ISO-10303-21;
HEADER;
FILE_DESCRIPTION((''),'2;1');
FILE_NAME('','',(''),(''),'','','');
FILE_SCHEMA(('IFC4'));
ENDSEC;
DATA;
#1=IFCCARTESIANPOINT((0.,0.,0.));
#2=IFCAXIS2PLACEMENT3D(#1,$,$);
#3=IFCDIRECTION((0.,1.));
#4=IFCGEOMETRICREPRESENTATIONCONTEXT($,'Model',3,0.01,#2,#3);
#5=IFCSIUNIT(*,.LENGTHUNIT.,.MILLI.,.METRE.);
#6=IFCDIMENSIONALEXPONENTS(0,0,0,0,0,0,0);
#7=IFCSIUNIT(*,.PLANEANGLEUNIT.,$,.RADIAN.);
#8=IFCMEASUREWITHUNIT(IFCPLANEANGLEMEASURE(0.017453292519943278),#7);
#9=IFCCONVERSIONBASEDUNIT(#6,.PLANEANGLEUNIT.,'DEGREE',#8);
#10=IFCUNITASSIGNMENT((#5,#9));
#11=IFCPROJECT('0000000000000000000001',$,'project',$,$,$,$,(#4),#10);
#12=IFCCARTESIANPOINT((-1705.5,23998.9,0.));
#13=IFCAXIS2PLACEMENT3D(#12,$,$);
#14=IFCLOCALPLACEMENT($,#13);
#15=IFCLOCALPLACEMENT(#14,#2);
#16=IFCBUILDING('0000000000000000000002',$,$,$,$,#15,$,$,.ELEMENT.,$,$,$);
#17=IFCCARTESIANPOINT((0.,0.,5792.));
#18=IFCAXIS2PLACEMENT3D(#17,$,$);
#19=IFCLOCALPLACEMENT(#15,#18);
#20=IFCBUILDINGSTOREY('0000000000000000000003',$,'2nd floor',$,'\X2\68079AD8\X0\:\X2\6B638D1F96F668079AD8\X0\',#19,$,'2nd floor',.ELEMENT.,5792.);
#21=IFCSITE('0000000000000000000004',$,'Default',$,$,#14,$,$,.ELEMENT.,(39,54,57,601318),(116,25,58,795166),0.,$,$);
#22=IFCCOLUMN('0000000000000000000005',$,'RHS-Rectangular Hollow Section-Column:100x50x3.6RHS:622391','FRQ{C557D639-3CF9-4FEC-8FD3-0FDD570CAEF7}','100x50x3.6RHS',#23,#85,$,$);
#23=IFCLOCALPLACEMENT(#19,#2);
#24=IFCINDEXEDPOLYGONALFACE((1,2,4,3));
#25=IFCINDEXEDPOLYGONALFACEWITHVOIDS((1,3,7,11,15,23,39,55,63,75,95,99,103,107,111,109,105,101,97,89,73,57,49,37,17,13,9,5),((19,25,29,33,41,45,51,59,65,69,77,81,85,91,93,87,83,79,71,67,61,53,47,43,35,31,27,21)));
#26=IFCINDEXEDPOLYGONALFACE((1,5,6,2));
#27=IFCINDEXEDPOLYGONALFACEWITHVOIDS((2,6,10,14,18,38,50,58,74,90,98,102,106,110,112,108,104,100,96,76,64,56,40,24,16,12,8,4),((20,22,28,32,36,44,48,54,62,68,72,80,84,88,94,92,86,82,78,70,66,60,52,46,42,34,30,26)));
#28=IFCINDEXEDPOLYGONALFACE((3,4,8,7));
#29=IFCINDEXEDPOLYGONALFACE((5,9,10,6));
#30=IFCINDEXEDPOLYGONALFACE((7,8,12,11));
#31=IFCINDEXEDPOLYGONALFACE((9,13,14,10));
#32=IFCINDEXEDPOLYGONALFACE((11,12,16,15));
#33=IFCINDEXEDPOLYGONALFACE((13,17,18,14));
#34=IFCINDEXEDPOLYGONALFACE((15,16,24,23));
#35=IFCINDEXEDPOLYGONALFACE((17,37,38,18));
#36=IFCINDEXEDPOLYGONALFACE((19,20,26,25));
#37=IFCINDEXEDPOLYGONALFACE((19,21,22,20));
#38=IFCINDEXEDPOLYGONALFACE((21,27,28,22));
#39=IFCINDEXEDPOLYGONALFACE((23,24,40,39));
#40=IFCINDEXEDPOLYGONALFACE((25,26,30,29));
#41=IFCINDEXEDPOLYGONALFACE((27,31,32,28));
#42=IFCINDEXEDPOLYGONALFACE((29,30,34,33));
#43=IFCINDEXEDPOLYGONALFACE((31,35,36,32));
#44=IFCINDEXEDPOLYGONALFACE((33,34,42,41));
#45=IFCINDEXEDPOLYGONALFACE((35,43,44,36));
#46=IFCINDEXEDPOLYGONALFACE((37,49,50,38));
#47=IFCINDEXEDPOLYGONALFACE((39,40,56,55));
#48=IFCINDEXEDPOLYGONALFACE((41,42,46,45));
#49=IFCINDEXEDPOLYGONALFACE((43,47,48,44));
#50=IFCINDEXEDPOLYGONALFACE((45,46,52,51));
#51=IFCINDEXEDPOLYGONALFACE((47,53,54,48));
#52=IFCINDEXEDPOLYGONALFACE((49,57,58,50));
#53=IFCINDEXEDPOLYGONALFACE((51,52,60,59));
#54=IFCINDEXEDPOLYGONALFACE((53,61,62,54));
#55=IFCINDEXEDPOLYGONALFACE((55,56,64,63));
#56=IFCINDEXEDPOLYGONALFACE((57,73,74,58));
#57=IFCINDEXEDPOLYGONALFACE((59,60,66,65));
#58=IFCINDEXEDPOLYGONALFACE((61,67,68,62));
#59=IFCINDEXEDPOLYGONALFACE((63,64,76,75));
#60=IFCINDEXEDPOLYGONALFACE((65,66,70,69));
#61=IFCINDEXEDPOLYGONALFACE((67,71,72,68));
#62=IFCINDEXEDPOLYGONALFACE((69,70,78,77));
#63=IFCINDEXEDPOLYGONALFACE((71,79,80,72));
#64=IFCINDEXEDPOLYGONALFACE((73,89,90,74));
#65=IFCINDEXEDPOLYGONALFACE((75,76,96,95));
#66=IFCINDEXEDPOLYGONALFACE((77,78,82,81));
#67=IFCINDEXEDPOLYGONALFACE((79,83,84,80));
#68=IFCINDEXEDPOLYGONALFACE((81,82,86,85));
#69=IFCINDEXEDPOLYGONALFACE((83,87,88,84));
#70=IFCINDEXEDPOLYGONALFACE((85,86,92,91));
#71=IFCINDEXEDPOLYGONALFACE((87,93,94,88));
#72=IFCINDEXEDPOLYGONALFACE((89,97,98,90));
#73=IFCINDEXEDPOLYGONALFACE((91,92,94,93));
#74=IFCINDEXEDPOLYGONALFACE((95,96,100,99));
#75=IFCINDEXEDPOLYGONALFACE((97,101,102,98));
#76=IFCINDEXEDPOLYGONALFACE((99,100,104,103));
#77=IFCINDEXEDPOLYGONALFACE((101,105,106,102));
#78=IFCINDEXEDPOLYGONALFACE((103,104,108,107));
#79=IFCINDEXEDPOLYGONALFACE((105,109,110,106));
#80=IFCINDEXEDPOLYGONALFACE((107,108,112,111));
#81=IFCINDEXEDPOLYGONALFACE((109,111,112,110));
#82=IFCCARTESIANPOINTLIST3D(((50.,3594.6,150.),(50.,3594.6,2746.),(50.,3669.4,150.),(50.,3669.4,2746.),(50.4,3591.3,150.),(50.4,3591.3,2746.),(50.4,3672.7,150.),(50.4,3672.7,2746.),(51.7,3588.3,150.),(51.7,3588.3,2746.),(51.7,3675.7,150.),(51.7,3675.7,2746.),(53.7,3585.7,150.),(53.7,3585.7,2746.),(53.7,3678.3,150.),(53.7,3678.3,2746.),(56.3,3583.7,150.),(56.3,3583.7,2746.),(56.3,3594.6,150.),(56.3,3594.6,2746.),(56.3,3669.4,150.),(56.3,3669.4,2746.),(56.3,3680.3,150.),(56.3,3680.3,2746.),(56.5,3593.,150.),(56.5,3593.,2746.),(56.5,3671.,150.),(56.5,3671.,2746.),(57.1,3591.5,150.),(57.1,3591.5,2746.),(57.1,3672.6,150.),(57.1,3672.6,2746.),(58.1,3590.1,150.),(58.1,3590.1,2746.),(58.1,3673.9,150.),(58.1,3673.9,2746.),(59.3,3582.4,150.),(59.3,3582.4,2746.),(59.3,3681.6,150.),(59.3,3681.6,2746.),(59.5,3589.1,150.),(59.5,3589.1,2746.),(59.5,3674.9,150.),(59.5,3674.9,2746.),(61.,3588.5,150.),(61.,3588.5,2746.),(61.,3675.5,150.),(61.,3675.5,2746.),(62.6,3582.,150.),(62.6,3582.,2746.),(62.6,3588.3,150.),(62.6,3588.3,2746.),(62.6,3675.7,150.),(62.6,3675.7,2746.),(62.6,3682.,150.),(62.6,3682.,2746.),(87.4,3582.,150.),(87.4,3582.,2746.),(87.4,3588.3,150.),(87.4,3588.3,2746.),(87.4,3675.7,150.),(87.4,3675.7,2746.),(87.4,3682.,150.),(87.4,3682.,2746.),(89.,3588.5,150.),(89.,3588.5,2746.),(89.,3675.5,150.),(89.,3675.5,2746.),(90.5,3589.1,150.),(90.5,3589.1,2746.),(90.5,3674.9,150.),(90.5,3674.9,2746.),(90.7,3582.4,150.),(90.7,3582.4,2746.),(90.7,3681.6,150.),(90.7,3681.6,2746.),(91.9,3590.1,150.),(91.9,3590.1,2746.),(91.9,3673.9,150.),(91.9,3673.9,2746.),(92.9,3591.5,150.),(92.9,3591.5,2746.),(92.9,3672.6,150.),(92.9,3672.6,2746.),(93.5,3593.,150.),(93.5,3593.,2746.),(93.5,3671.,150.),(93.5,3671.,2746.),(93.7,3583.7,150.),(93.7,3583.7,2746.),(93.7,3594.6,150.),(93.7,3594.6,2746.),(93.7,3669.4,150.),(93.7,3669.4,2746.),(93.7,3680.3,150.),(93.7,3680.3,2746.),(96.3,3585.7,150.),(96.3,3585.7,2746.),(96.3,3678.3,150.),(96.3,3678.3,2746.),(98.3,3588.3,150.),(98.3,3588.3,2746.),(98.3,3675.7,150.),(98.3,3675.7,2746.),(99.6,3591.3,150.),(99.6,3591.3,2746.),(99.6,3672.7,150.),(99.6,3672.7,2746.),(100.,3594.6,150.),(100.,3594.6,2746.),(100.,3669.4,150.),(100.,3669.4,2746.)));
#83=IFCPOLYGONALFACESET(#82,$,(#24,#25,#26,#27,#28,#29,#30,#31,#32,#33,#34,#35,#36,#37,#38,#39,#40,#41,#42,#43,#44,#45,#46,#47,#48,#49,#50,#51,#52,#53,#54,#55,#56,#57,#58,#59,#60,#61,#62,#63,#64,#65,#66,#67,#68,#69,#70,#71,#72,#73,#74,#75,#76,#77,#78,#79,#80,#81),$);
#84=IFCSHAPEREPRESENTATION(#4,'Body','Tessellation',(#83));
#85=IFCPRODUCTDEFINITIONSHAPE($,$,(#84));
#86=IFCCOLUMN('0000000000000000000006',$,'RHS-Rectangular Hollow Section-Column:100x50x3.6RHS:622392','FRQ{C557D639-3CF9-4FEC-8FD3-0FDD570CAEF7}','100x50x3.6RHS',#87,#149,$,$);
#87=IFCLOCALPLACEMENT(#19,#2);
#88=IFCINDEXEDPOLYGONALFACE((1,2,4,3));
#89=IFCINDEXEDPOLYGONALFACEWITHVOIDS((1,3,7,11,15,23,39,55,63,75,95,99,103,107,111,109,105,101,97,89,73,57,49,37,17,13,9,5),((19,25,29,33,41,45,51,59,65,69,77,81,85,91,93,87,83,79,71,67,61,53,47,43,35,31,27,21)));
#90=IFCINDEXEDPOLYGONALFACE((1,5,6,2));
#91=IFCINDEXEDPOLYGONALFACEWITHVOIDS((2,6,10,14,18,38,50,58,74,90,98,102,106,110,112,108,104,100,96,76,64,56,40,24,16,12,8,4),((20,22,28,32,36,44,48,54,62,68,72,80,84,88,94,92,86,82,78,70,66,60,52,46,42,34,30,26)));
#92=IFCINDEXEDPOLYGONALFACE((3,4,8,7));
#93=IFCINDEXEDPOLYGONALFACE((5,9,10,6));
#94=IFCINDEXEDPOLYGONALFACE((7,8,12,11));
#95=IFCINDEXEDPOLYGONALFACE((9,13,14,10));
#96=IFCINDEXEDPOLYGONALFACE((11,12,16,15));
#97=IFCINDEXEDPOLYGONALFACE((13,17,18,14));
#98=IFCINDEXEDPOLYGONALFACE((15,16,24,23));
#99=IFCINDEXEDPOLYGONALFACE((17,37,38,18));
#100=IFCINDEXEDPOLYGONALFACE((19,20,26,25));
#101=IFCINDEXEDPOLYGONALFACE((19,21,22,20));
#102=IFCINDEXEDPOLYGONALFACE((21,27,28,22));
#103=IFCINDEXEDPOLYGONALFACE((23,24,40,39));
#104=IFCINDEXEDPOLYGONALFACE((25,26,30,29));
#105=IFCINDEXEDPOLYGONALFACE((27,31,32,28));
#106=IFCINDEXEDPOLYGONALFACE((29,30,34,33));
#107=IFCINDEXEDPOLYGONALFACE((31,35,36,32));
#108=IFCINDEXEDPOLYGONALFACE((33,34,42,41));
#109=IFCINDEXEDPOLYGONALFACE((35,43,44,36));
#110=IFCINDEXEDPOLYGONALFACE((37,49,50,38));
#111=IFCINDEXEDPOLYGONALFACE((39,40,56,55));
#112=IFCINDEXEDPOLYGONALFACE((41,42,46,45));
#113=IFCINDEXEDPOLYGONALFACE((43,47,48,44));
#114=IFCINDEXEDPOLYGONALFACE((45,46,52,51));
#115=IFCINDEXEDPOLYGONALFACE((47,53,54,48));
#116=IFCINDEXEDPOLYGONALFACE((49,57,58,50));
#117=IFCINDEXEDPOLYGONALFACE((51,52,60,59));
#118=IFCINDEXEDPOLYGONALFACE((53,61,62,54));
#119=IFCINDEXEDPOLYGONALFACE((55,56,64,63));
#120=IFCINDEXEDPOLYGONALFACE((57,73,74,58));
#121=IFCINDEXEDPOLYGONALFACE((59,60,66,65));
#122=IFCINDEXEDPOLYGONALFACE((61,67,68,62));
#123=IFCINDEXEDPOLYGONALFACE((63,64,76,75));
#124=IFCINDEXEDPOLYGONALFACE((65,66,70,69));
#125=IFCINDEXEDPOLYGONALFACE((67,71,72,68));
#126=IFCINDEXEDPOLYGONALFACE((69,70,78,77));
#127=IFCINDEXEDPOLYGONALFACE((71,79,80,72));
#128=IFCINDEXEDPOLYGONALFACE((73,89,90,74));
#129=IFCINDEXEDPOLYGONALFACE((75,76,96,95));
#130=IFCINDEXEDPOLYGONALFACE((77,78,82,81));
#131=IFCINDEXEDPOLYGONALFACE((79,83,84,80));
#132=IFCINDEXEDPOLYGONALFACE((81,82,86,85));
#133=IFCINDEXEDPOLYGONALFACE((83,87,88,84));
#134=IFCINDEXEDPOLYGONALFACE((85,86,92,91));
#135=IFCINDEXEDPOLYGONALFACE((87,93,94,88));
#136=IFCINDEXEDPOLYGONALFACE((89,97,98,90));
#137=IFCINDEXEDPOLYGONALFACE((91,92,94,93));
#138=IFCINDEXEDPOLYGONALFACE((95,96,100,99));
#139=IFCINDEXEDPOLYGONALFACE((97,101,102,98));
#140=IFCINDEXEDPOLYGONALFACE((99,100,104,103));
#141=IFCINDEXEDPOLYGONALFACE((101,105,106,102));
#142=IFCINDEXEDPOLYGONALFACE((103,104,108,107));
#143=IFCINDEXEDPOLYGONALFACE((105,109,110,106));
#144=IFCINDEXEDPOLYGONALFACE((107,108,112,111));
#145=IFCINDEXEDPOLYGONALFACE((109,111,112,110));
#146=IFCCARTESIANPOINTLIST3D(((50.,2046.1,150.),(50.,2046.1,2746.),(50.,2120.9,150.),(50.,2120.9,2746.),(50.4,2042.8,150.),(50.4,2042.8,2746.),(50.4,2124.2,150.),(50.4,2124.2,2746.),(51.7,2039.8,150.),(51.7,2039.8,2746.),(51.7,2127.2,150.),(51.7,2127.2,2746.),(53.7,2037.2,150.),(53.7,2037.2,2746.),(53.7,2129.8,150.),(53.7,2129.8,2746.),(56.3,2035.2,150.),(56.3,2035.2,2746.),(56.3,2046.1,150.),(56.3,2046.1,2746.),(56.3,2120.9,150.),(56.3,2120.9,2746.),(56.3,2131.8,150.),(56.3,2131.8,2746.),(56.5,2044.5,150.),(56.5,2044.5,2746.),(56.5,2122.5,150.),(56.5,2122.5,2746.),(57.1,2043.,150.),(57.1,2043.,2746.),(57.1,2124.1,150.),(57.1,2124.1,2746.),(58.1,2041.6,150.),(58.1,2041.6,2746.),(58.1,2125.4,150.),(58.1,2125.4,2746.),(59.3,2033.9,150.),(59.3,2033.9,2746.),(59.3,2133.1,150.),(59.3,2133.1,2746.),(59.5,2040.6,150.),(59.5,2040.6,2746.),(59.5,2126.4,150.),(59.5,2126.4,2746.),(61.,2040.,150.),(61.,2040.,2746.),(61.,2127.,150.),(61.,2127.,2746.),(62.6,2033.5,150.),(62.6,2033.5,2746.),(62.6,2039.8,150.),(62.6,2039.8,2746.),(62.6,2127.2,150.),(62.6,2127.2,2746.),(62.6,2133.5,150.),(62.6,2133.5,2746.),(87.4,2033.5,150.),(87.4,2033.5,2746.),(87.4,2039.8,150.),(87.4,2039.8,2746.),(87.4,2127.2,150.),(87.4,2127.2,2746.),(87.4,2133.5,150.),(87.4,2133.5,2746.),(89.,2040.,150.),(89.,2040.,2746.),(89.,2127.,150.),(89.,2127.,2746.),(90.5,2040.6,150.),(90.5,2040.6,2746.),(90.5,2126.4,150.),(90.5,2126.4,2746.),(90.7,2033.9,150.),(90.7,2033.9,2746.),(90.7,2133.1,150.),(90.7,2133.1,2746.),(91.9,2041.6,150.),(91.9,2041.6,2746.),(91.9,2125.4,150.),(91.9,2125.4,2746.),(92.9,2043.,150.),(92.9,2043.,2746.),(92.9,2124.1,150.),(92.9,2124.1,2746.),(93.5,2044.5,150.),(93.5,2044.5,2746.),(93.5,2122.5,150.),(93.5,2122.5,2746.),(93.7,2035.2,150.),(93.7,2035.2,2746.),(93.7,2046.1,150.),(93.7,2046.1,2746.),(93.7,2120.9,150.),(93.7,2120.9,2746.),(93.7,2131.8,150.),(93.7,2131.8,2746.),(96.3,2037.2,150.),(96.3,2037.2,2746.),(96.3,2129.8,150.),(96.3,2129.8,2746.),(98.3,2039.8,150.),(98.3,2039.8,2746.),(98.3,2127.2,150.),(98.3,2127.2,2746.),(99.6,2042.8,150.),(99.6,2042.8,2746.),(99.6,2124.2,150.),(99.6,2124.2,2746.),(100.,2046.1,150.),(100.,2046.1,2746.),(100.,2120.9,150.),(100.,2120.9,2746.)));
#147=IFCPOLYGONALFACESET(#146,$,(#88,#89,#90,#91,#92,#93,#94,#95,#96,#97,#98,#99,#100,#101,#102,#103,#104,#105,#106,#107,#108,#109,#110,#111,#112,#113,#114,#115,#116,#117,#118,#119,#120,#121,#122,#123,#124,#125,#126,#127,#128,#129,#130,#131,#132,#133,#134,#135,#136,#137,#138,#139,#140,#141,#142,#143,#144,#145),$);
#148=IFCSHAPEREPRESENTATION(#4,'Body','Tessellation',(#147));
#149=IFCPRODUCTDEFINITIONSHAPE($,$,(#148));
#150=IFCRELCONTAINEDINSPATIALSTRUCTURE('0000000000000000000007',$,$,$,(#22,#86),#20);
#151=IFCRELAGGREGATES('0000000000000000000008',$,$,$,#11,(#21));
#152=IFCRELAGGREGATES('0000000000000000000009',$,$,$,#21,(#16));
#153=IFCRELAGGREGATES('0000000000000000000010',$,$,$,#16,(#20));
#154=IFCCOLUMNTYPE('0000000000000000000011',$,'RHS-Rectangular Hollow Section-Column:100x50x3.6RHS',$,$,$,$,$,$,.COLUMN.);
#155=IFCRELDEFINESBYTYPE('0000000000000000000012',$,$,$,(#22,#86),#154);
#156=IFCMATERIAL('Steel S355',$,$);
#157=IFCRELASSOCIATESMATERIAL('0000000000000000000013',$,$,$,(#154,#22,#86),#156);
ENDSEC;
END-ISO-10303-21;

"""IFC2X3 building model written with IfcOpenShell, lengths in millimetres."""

from ifc_helpers import new_model, entity, si_unit, converted_unit, direction, frame, origin, origin_2d, place, context, project, spatial, hollow_rectangle, extrude, clip, halfspace, material, type_object, element, save


model = new_model("IFC2X3")

# Units and contexts
model_context = context("Model", 3, precision=0.01, world=origin(), true_north=direction((0.0, 1.0)))
ifc_project = project(units=[si_unit("LENGTHUNIT", "METRE", prefix="MILLI"), converted_unit("PLANEANGLEUNIT", "DEGREE", entity("IfcPlaneAngleMeasure", 0.017453292519943278), si_unit("PLANEANGLEUNIT", "RADIAN"), dimensions=[0, 0, 0, 0, 0, 0, 0])], contexts=[model_context])

# Site, building, storey
site_placement = place(None, frame((-1705.5, 23998.9, 0.0)))
site = spatial("IfcSite", under=ifc_project, at=site_placement, Name="Default", CompositionType="ELEMENT", RefLatitude=(39, 54, 57, 601318), RefLongitude=(116, 25, 58, 795166), RefElevation=0.0)
building_placement = place(site_placement, origin())
building = spatial("IfcBuilding", under=site, at=building_placement, CompositionType="ELEMENT")
storey_placement = place(building_placement, frame((0.0, 0.0, 5792.0)))
storey = spatial("IfcBuildingStorey", under=building, at=storey_placement, Name="2nd floor", ObjectType="标高:正负零标高", LongName="2nd floor", CompositionType="ELEMENT", Elevation=5792.0)

# Columns
ifc_material_1 = material(Name="Steel S355")
column_type_1 = type_object("IfcColumnType", Name="RHS-Rectangular Hollow Section-Column:100x50x3.6RHS", PredefinedType="COLUMN", material=ifc_material_1)
column_1_placement = place(storey_placement, frame((75.0, 3632.0, 2746.0), z_axis=(0.0, 0.0, 1.0), x_axis=(-1.0, 0.0, 0.0)))
element("IfcColumn", 1, at=column_1_placement, inside=storey, type_object=column_type_1, material=ifc_material_1, Name="RHS-Rectangular Hollow Section-Column:100x50x3.6RHS:622391", Description="FRQ{C557D639-3CF9-4FEC-8FD3-0FDD570CAEF7}", ObjectType="100x50x3.6RHS", context=model_context, shape_type="Clipping", body=[
    clip(extrude(hollow_rectangle(XDim=50.0, YDim=100.0, WallThickness=6.3, InnerFilletRadius=6.3, OuterFilletRadius=12.6, at=origin_2d()), origin(), (0.0, 0.0, -1.0), 2651.9), halfspace(frame((75.0, 3632.0, -2596.0), z_axis=(0.0, 0.0, 1.0), x_axis=(-1.0, 0.0, 0.0)), True)),
])
column_2_placement = place(storey_placement, frame((75.0, 2083.5, 2746.0), z_axis=(0.0, 0.0, 1.0), x_axis=(-1.0, 0.0, 0.0)))
element("IfcColumn", 2, at=column_2_placement, inside=storey, type_object=column_type_1, material=ifc_material_1, Name="RHS-Rectangular Hollow Section-Column:100x50x3.6RHS:622392", Description="FRQ{C557D639-3CF9-4FEC-8FD3-0FDD570CAEF7}", ObjectType="100x50x3.6RHS", context=model_context, shape_type="Clipping", body=[
    clip(extrude(hollow_rectangle(XDim=50.0, YDim=100.0, WallThickness=6.3, InnerFilletRadius=6.3, OuterFilletRadius=12.6, at=origin_2d()), origin(), (0.0, 0.0, -1.0), 2651.9), halfspace(frame((75.0, 2083.5, -2596.0), z_axis=(0.0, 0.0, 1.0), x_axis=(-1.0, 0.0, 0.0)), True)),
])

save(model, "model.ifc")
